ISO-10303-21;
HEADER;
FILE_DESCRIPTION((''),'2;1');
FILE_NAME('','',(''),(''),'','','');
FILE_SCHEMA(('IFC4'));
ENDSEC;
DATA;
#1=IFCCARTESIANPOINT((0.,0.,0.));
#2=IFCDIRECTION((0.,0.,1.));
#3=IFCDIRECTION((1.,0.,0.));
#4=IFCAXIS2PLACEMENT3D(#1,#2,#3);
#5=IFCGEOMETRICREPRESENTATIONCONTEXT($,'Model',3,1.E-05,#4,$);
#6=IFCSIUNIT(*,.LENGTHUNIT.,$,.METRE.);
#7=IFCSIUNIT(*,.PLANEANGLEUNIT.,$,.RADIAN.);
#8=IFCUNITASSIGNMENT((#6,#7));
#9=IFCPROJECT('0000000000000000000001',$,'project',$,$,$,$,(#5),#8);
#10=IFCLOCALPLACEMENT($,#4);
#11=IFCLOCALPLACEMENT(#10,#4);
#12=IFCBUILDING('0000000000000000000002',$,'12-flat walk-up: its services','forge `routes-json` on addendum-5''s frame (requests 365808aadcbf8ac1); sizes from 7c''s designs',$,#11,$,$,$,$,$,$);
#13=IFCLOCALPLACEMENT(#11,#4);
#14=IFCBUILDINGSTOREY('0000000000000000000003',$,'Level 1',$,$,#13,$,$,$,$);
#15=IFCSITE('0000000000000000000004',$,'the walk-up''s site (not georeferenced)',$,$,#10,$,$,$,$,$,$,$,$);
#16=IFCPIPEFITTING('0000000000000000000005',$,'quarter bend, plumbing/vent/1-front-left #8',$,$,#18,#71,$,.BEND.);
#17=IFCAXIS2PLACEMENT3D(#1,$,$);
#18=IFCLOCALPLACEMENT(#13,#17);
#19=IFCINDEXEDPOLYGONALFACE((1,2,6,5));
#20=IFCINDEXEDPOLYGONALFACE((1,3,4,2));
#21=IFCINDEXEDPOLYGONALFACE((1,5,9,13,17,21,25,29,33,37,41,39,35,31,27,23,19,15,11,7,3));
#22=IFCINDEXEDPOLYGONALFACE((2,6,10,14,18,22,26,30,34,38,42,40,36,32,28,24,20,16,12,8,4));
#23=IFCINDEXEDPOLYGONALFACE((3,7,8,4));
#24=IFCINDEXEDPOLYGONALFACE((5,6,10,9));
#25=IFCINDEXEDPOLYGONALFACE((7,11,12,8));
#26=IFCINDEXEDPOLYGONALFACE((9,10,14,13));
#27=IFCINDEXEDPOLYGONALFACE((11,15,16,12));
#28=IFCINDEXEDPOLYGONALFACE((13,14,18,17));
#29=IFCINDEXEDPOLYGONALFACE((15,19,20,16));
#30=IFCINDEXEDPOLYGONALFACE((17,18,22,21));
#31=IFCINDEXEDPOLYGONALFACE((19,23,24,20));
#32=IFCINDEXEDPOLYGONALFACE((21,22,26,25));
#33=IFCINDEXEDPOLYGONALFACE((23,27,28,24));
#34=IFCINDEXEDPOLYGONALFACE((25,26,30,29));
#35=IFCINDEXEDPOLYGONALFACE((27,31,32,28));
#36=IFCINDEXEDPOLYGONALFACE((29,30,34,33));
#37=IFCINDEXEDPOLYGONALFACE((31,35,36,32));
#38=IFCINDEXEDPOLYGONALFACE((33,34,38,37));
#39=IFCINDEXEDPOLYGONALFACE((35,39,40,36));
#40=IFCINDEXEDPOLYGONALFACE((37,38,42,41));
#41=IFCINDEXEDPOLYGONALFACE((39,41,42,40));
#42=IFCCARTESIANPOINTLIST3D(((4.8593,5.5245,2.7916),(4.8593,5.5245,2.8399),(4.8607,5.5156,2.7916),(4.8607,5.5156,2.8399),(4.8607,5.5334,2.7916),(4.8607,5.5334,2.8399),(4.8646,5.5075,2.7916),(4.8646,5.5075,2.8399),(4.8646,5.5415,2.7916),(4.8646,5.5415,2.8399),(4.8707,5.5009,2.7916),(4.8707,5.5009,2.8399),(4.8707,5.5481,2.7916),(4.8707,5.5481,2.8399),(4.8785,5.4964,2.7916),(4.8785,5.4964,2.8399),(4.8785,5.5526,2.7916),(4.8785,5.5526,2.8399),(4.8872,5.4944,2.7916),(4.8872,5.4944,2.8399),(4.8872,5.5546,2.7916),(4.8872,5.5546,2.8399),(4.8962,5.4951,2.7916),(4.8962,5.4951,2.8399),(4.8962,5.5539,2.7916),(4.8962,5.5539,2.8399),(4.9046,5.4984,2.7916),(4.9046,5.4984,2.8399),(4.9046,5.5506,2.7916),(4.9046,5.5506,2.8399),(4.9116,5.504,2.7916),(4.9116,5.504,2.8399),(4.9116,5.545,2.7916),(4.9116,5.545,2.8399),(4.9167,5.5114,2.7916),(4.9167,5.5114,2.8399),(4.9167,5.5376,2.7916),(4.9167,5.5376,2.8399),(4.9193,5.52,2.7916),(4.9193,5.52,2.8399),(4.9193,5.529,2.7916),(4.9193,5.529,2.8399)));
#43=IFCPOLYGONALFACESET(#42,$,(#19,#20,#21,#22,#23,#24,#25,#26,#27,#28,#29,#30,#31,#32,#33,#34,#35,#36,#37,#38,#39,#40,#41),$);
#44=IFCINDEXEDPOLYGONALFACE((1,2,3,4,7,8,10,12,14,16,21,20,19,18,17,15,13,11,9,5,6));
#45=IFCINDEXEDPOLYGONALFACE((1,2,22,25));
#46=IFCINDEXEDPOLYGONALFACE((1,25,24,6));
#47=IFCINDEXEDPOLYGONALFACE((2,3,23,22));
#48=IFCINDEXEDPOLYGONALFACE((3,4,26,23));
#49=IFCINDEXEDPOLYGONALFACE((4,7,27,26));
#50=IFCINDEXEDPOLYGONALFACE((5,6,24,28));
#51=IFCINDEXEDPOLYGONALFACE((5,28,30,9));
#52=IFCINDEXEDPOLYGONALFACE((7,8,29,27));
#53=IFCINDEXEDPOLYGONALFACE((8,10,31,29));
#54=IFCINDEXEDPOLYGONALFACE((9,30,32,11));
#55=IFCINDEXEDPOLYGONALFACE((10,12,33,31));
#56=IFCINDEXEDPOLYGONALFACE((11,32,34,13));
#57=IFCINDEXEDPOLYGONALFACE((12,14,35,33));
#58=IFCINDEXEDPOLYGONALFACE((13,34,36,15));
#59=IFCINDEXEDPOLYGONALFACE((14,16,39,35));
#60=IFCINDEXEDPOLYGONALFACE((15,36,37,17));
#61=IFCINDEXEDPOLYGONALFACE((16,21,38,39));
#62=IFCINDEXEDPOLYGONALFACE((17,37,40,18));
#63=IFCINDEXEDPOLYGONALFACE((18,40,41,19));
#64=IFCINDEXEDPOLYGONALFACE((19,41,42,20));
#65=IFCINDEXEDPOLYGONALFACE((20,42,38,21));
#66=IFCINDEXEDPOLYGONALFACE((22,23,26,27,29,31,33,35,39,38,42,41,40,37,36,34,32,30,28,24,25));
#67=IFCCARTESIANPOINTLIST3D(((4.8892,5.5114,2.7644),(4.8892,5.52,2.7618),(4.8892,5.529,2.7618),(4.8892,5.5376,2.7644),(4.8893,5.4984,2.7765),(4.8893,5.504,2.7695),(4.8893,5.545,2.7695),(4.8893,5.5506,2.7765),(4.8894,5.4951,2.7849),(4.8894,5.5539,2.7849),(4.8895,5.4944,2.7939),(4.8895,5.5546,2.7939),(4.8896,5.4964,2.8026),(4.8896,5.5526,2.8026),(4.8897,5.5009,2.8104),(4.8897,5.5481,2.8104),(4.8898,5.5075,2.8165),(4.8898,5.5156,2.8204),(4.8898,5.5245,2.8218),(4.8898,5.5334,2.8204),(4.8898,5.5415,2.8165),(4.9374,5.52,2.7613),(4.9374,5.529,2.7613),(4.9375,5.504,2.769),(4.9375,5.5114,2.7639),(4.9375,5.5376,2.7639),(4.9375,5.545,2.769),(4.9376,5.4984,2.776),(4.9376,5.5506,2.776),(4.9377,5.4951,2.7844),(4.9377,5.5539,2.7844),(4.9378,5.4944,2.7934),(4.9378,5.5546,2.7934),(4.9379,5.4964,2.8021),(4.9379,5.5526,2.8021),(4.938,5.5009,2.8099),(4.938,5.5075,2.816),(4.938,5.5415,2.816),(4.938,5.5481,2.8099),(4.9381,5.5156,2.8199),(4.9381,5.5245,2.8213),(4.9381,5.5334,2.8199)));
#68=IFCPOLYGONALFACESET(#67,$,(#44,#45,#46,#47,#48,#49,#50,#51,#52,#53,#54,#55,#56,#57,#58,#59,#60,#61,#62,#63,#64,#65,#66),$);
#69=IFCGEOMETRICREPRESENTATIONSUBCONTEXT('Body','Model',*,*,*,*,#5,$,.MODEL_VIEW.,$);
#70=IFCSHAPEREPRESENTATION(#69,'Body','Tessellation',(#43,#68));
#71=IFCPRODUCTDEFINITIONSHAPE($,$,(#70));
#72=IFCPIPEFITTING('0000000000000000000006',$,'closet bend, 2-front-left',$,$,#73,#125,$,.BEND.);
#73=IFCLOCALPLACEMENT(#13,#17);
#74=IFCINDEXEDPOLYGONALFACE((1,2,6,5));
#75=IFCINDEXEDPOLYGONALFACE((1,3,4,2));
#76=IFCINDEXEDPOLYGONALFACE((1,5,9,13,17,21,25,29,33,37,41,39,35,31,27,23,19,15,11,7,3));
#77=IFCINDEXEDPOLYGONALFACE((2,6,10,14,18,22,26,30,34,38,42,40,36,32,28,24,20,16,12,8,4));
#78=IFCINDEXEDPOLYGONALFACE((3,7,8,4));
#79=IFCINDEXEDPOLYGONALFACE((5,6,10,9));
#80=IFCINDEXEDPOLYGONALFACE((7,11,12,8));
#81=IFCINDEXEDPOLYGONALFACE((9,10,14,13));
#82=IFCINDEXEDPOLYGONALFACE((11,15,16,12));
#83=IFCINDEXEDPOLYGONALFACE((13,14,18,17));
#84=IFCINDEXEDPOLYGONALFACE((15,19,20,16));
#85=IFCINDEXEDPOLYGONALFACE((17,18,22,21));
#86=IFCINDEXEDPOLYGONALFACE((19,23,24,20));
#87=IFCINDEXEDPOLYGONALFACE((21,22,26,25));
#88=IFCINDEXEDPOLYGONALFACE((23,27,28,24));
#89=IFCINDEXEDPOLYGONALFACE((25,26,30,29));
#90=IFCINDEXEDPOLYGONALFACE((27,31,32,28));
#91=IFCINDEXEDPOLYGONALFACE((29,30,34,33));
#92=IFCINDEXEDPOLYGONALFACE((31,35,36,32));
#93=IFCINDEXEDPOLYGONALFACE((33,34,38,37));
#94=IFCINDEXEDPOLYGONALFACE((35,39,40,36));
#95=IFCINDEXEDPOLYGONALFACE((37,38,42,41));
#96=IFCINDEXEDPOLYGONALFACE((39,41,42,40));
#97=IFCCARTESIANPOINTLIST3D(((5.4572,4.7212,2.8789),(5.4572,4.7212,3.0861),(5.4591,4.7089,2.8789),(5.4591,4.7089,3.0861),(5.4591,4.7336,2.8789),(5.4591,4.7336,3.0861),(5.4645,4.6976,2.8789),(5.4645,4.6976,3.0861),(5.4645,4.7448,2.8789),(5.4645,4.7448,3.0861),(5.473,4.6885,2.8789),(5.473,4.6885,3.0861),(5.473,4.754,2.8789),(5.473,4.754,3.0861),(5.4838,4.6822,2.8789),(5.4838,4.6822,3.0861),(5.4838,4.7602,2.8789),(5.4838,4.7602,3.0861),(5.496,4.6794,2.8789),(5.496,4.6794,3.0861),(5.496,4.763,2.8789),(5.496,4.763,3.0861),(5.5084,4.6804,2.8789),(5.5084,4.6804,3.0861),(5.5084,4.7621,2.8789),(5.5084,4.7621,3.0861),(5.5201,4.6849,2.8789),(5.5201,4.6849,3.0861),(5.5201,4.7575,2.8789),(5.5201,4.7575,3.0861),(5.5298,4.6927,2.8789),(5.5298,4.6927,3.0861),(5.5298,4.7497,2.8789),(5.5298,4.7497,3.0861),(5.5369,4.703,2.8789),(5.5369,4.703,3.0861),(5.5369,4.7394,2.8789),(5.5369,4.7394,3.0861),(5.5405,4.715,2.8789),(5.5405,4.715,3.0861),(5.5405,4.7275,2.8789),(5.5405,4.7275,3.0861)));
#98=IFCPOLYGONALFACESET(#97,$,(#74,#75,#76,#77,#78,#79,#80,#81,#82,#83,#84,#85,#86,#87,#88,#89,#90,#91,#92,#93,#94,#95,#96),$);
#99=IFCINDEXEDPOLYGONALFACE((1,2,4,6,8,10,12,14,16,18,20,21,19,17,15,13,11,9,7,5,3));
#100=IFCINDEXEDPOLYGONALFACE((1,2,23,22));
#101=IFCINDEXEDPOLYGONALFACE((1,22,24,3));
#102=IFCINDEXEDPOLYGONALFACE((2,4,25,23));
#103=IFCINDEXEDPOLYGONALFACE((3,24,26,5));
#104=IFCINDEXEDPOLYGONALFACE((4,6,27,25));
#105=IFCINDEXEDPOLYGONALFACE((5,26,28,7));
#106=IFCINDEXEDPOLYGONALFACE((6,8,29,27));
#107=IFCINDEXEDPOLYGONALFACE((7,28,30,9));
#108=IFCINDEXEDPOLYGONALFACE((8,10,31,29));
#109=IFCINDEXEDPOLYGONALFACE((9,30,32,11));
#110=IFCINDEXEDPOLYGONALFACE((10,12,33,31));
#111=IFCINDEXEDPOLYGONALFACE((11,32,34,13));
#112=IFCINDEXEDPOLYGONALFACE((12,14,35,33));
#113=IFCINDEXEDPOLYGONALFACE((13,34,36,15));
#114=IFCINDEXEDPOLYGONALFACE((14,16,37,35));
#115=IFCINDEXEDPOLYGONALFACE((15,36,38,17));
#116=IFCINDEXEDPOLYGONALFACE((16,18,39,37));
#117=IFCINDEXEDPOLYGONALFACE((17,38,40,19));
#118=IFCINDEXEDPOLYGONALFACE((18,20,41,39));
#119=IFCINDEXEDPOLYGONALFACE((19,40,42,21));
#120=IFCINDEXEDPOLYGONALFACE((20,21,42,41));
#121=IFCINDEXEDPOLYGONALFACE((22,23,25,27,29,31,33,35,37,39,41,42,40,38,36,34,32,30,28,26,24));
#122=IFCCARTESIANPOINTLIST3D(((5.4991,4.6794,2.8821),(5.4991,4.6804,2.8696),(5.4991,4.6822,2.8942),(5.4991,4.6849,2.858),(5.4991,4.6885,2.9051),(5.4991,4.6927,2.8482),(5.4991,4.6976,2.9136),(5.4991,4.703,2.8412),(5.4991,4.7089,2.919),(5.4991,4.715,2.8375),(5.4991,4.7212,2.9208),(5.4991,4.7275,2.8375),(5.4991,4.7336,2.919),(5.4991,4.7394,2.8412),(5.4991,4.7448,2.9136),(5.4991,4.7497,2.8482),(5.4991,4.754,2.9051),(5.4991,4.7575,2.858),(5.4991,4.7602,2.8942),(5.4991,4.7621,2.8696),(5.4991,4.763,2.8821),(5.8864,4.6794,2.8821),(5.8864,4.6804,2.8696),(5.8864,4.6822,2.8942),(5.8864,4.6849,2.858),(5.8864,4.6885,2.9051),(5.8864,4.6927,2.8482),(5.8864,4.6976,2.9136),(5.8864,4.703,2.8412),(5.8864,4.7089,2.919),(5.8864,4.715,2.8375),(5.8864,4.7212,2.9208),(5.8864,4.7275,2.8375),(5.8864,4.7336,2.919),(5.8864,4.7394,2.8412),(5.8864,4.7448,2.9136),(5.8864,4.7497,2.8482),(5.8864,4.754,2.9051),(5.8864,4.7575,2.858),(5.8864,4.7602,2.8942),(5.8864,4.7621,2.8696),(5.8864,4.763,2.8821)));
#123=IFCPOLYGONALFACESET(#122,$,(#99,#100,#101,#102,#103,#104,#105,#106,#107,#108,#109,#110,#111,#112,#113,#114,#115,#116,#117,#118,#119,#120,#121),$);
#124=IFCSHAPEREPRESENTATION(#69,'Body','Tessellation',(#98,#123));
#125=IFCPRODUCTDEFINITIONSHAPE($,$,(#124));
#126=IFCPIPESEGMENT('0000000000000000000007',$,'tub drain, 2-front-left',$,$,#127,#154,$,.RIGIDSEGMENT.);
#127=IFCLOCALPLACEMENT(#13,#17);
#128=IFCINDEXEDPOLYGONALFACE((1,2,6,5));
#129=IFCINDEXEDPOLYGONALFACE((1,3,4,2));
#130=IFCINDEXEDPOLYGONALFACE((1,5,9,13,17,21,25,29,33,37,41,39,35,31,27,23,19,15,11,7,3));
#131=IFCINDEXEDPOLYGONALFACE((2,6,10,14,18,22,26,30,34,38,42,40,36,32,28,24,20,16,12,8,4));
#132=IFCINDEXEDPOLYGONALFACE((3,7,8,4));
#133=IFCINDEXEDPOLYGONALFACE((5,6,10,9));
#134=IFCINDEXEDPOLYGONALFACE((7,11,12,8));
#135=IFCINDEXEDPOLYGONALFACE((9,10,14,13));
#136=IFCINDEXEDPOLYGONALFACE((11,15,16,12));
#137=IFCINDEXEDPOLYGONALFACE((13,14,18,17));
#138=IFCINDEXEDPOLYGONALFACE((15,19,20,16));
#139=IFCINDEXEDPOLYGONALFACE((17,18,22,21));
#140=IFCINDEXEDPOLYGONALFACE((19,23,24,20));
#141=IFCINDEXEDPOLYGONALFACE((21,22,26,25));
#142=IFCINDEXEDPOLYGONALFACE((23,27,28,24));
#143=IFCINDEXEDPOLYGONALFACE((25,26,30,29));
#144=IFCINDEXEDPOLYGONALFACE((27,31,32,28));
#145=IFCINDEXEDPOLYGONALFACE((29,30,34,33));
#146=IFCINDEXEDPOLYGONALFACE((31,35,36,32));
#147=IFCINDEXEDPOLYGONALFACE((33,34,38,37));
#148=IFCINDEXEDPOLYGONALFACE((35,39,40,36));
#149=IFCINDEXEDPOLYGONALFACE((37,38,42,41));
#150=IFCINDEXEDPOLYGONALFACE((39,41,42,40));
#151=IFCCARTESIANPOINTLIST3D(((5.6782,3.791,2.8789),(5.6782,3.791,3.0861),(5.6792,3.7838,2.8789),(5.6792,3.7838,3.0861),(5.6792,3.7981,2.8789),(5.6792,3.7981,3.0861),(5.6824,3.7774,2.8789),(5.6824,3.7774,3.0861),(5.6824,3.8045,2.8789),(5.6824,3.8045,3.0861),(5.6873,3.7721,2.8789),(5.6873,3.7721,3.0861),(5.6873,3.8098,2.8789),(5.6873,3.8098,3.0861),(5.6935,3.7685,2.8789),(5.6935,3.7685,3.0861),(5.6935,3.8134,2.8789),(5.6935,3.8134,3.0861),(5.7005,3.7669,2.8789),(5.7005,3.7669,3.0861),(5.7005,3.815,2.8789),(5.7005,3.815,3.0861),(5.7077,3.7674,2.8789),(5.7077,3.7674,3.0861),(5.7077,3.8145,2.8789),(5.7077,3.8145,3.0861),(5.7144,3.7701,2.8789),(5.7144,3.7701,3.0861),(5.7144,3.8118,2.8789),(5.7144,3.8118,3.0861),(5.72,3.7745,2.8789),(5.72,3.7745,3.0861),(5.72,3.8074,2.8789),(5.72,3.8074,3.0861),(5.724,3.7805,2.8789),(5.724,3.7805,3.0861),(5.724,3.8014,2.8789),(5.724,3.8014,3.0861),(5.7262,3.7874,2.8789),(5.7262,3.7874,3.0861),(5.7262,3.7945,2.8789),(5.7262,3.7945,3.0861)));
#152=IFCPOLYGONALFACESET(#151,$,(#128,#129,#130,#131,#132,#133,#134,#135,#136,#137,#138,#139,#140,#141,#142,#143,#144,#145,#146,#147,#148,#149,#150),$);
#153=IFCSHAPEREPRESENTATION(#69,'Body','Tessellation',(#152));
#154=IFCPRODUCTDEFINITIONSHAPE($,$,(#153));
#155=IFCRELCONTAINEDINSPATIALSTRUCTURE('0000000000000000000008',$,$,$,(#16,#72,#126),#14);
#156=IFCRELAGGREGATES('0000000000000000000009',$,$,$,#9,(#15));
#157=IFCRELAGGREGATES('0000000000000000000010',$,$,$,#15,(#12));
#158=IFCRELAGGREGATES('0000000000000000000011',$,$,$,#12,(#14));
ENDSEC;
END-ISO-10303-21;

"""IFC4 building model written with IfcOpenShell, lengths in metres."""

from ifc_helpers import new_model, entity, si_unit, frame, origin_with_axes, place, context, subcontext, project, spatial, element, save


model = new_model("IFC4")

# Units and contexts
model_context = context("Model", 3, precision=1e-05, world=origin_with_axes())
body_context = subcontext(model_context, "Body", "Model", "MODEL_VIEW")
ifc_project = project(units=[si_unit("LENGTHUNIT", "METRE"), si_unit("PLANEANGLEUNIT", "RADIAN")], contexts=[model_context])

# Site, building, storey
site_placement = place(None, origin_with_axes())
site = spatial("IfcSite", under=ifc_project, at=site_placement, Name="the walk-up's site (not georeferenced)")
building_placement = place(site_placement, origin_with_axes())
building = spatial("IfcBuilding", under=site, at=building_placement, Name="12-flat walk-up: its services", Description="forge `routes-json` on addendum-5's frame (requests 365808aadcbf8ac1); sizes from 7c's designs")
storey_placement = place(building_placement, origin_with_axes())
storey = spatial("IfcBuildingStorey", under=building, at=storey_placement, Name="Level 1")

# Pipe fittings
pipe_fitting_1_placement = place(storey_placement, frame((4.8895, 5.5245, 2.8399), z_axis=(0.0, 0.0, 1.0), x_axis=(1.0, 0.0, 0.0)))
element("IfcPipeFitting", 1, at=pipe_fitting_1_placement, inside=storey, Name="quarter bend, plumbing/vent/1-front-left #8", PredefinedType="BEND", context=body_context, shape_type="AdvancedSweptSolid", body=[
    entity("IfcSweptDiskSolid", entity("IfcPolyline", [entity("IfcCartesianPoint", [0.0, 0.0, 0.0]), entity("IfcCartesianPoint", [0.0, 0.0, -0.0483])]), 0.0302),
    entity("IfcSweptDiskSolid", entity("IfcPolyline", [entity("IfcCartesianPoint", [0.0, 0.0, -0.0483]), entity("IfcCartesianPoint", [0.0483, 0.0, -0.0488])]), 0.0302),
])
pipe_fitting_2_placement = place(storey_placement, frame((5.4991, 4.7212, 3.0861), z_axis=(0.0, 0.0, 1.0), x_axis=(1.0, 0.0, 0.0)))
element("IfcPipeFitting", 2, at=pipe_fitting_2_placement, inside=storey, Name="closet bend, 2-front-left", PredefinedType="BEND", context=body_context, shape_type="AdvancedSweptSolid", body=[
    entity("IfcSweptDiskSolid", entity("IfcPolyline", [entity("IfcCartesianPoint", [0.0, 0.0, 0.0]), entity("IfcCartesianPoint", [0.0, 0.0, -0.2072])]), 0.0419),
    entity("IfcSweptDiskSolid", entity("IfcPolyline", [entity("IfcCartesianPoint", [0.0, 0.0, -0.2072]), entity("IfcCartesianPoint", [0.3874, 0.0, -0.2072])]), 0.0419),
])

# Pipe segment
pipe_segment_1_placement = place(storey_placement, frame((5.7023, 3.791, 3.0861), z_axis=(0.0, 0.0, 1.0), x_axis=(1.0, 0.0, 0.0)))
element("IfcPipeSegment", 3, at=pipe_segment_1_placement, inside=storey, Name="tub drain, 2-front-left", PredefinedType="RIGIDSEGMENT", context=body_context, shape_type="AdvancedSweptSolid", body=[
    entity("IfcSweptDiskSolid", entity("IfcPolyline", [entity("IfcCartesianPoint", [0.0, 0.0, 0.0]), entity("IfcCartesianPoint", [0.0, 0.0, -0.2072])]), 0.0241),
])

save(model, "model.ifc")
